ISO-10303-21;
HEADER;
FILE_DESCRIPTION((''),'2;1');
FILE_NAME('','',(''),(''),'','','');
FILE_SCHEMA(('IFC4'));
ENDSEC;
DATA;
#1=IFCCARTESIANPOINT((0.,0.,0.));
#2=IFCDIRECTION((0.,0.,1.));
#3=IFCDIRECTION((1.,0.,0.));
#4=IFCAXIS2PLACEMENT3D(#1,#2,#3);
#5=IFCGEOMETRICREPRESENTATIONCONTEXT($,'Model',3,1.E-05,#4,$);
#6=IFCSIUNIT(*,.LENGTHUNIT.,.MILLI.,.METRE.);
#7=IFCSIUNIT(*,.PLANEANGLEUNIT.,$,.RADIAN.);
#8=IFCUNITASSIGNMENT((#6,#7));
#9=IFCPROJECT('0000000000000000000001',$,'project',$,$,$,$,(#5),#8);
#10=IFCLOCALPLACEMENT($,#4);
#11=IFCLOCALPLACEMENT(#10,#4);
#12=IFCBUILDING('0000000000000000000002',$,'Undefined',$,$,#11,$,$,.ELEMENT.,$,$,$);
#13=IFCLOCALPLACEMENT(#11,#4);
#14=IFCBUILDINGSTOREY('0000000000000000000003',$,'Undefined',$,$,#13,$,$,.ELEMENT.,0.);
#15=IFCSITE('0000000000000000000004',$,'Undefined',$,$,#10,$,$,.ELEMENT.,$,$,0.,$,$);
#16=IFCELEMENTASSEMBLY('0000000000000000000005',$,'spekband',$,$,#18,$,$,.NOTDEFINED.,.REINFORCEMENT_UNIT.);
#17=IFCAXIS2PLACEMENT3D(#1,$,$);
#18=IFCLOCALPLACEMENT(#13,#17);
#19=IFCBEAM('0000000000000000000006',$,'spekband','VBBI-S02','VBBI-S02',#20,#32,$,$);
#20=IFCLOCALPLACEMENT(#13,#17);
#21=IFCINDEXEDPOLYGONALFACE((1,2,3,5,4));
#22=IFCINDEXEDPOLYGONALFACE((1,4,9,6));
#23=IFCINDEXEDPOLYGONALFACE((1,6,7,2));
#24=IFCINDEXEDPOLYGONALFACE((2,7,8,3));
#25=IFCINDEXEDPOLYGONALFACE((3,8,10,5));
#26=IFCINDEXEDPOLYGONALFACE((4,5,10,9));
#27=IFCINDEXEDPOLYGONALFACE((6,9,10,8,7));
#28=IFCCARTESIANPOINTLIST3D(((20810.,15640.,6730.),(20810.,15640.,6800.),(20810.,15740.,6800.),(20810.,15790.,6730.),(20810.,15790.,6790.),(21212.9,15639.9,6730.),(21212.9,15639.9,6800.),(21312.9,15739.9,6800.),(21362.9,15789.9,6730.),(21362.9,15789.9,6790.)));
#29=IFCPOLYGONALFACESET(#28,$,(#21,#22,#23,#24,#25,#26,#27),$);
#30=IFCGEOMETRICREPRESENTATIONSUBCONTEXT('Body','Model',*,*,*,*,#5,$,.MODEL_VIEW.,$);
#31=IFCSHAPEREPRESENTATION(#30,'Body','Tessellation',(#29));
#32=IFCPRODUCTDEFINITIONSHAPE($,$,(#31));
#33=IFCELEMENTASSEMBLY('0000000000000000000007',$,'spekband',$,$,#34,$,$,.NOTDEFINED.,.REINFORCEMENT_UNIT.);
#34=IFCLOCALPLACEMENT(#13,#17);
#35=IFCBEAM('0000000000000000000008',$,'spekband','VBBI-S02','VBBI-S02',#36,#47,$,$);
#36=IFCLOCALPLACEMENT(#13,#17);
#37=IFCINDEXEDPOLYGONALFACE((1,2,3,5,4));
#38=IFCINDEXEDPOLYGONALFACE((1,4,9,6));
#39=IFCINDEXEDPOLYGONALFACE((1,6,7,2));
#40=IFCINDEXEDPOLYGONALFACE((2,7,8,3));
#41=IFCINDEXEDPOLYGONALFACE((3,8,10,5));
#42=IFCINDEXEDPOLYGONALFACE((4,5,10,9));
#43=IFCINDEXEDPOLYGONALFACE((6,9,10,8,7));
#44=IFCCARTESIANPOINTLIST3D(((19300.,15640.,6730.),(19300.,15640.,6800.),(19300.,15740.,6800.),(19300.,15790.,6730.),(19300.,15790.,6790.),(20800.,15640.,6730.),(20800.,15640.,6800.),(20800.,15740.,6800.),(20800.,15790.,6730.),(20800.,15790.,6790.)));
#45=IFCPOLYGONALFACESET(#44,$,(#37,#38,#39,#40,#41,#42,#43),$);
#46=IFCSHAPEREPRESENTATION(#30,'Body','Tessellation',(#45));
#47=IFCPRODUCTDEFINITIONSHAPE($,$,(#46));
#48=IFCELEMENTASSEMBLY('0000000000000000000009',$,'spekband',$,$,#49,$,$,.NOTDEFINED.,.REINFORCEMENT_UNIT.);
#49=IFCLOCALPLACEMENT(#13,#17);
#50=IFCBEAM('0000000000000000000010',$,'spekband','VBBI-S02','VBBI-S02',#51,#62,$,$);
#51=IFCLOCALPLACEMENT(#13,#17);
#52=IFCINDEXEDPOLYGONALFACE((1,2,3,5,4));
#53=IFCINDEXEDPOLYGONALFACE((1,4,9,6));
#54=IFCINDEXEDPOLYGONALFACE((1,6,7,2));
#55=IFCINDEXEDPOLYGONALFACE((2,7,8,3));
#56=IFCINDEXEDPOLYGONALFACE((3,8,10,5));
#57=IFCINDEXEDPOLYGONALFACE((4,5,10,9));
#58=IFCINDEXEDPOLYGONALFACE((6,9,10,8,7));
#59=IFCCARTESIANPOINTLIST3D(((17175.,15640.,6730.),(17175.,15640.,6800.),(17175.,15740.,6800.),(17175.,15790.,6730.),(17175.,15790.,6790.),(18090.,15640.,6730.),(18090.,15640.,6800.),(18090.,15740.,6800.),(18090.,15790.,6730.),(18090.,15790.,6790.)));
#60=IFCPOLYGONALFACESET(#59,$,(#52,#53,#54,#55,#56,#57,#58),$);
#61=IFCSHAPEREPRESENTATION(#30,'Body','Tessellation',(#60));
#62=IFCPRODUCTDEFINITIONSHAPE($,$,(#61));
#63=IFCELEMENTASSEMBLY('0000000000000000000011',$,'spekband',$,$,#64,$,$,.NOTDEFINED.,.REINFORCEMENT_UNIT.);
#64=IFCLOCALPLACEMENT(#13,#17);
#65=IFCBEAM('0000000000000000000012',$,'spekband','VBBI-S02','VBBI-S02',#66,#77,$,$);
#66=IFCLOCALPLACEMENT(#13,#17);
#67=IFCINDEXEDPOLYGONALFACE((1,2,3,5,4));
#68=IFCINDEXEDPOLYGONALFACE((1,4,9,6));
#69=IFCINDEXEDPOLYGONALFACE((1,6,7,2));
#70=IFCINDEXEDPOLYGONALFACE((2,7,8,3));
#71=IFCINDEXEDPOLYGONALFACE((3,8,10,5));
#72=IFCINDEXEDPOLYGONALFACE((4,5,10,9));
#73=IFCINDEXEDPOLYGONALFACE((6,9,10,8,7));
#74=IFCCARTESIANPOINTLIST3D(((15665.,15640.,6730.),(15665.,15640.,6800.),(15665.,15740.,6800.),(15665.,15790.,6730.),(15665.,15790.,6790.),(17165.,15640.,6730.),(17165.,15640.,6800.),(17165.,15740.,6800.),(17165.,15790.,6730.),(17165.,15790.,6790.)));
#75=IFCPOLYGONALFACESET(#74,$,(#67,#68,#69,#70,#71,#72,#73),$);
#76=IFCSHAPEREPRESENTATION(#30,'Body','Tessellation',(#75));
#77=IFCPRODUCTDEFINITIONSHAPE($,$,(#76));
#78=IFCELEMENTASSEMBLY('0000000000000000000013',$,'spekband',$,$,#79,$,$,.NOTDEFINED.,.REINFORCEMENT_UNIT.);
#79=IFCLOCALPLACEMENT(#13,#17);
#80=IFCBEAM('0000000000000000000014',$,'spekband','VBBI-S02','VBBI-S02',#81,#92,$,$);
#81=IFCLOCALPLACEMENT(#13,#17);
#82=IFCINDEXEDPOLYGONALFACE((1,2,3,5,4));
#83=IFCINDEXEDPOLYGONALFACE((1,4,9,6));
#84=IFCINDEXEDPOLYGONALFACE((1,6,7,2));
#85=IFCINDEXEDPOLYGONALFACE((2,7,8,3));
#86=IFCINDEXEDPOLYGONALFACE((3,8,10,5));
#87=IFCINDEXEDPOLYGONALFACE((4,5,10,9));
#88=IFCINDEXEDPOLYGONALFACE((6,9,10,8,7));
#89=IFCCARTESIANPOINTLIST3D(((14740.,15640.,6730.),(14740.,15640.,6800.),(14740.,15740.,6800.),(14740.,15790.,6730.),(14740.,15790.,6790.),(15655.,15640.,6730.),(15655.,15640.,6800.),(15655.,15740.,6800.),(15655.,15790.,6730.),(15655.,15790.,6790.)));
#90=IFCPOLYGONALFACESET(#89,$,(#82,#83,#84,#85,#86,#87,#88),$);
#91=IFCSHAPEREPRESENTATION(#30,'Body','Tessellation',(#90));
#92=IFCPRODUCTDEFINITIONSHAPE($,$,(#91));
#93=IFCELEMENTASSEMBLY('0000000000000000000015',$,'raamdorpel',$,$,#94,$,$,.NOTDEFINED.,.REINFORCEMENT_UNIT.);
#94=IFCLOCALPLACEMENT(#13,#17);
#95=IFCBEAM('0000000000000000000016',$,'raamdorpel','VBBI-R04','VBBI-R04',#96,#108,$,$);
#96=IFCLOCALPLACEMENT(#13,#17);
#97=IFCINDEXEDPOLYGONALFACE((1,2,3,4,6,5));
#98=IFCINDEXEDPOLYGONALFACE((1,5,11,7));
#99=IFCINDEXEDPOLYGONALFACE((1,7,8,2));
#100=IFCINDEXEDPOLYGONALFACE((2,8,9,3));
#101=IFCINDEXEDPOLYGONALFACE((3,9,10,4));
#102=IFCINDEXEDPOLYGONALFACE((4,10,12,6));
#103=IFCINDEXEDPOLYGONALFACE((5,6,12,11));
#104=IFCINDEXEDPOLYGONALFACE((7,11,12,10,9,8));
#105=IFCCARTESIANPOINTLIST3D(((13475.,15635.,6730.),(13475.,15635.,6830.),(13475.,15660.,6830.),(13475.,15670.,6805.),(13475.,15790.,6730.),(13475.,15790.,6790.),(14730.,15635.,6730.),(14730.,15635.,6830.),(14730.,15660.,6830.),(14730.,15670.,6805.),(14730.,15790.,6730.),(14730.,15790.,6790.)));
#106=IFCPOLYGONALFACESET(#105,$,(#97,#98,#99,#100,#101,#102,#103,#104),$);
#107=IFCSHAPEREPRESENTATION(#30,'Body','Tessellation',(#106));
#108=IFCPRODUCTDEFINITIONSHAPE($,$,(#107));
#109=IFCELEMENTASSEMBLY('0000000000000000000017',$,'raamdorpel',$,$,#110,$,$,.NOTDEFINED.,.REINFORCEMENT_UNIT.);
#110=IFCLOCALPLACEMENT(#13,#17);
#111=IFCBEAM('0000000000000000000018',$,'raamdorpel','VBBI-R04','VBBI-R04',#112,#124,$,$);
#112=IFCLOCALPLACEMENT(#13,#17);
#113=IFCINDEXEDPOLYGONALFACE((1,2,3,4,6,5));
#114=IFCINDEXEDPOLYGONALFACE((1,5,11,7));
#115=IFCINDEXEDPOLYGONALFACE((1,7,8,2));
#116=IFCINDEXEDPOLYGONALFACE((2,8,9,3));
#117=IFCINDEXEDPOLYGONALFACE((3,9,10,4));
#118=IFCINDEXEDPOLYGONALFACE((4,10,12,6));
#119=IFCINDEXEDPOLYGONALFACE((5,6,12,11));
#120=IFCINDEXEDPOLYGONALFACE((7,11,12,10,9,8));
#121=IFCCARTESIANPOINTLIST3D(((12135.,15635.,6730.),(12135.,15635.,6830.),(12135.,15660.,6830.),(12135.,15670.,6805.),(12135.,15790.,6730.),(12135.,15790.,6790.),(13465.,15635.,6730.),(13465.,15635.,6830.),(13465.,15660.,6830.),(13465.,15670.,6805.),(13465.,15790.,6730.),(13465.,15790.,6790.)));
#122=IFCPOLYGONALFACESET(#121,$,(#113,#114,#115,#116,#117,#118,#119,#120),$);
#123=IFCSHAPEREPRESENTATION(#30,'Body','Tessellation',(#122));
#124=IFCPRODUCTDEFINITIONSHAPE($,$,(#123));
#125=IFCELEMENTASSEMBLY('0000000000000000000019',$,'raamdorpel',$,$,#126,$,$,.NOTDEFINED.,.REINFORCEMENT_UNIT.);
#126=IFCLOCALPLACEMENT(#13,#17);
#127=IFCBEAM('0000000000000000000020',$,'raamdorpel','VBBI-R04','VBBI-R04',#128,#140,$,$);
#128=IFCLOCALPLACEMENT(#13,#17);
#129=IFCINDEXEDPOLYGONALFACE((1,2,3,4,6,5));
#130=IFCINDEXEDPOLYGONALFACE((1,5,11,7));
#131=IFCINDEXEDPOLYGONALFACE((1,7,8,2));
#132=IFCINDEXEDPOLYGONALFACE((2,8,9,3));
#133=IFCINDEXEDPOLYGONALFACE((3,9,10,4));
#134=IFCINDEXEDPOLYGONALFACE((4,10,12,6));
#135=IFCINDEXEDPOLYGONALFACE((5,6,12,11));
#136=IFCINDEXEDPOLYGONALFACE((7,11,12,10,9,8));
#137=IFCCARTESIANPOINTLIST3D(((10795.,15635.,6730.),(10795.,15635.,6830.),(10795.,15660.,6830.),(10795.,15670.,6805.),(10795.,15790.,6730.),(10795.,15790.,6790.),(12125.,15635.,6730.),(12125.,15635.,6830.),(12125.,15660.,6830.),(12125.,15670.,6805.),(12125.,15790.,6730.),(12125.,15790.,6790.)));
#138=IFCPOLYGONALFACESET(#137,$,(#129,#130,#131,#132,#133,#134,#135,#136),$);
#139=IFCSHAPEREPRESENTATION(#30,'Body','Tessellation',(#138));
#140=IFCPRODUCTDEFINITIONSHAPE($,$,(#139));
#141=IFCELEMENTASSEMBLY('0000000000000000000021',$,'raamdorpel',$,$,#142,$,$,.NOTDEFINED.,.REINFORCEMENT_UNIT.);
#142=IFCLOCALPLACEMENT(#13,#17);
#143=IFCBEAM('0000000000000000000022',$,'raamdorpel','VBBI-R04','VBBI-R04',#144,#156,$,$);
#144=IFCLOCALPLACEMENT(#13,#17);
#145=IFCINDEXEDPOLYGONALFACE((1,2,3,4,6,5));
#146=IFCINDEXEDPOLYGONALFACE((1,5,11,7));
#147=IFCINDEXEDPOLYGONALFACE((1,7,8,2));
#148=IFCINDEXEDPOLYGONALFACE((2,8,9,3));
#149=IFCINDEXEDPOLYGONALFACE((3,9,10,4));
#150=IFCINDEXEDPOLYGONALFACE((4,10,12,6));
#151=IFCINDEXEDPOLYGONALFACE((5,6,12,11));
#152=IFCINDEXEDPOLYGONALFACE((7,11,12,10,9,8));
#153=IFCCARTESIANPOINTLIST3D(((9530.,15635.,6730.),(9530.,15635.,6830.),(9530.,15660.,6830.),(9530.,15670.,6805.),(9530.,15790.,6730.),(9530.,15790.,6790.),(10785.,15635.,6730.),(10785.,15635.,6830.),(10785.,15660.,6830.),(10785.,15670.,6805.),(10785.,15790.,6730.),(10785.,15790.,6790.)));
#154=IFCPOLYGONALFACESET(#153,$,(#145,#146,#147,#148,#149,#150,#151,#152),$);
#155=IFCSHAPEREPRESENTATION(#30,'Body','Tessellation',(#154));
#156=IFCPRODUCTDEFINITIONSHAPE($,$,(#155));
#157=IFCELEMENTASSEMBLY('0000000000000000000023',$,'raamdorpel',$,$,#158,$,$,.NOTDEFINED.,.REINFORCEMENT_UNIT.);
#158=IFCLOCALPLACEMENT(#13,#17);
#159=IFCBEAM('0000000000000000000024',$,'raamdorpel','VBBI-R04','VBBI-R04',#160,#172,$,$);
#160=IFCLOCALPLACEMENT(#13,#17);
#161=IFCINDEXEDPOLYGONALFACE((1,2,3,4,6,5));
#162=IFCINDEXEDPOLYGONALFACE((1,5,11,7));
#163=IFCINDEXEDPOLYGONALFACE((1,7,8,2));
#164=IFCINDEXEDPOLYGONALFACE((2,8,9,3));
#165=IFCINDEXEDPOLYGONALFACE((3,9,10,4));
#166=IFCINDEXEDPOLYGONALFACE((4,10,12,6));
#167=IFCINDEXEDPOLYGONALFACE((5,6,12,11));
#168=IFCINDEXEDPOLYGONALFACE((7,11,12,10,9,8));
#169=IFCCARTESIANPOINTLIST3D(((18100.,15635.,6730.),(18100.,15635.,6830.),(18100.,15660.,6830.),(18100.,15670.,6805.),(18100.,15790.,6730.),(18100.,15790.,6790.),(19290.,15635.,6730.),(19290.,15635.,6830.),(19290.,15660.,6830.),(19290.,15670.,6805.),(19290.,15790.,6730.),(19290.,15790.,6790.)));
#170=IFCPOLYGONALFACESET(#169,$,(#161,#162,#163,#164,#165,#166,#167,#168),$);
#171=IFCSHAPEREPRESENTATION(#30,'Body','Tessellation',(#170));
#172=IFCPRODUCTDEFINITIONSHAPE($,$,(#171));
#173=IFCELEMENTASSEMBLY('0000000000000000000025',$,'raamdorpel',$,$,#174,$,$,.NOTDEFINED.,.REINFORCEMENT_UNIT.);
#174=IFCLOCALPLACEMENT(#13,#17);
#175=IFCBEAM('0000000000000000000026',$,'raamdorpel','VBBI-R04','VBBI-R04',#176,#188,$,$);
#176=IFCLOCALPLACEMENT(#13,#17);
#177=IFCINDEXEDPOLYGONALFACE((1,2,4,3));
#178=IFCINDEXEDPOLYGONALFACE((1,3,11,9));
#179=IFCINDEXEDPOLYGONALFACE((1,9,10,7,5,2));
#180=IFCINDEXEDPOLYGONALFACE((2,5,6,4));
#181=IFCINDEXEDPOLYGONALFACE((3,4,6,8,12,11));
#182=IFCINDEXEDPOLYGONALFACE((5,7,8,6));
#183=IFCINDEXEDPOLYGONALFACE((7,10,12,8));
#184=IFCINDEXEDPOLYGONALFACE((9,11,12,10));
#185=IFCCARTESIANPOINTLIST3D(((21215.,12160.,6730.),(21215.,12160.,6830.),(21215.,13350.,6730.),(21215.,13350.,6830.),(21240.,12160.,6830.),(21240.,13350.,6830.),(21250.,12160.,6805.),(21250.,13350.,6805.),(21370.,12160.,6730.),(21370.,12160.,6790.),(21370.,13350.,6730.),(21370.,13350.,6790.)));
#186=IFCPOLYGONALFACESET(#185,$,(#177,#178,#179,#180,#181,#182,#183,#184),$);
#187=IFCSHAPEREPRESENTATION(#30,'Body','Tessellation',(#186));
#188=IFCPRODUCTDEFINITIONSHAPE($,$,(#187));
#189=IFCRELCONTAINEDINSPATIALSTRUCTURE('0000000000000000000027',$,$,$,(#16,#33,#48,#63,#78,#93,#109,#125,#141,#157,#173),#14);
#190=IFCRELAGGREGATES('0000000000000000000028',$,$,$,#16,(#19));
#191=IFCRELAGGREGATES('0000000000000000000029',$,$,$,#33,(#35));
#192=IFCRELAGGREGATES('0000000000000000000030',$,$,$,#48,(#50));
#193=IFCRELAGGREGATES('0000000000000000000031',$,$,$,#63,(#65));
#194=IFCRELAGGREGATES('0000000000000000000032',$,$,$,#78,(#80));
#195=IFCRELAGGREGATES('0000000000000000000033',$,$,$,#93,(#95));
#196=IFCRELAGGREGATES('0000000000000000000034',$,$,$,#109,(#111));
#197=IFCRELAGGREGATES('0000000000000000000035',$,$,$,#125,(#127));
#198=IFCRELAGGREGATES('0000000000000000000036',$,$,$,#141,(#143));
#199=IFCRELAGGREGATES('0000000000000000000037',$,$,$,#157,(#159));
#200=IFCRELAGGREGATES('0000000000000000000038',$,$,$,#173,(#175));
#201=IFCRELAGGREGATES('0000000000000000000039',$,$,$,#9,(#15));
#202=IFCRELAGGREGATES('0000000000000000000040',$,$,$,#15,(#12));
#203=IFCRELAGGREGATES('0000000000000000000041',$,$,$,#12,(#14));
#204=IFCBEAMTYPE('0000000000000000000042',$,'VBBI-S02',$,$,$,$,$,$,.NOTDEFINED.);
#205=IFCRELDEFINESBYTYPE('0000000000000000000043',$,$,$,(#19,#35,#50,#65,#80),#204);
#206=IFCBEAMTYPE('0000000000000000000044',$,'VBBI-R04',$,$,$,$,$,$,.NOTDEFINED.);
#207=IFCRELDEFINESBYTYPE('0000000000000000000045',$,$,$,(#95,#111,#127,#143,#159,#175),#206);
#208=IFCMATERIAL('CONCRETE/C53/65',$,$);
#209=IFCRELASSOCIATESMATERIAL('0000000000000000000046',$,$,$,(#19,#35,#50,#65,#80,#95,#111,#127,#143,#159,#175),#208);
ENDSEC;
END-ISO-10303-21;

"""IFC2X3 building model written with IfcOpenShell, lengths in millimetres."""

from ifc_helpers import new_model, si_unit, frame, origin_with_axes, place, context, subcontext, project, spatial, polyline, outline, extrude, clip, halfspace, material, type_object, element, aggregate, save


model = new_model("IFC2X3")

# Units and contexts
model_context = context("Model", 3, precision=1e-05, world=origin_with_axes())
body_context = subcontext(model_context, "Body", "Model", "MODEL_VIEW")
ifc_project = project(units=[si_unit("LENGTHUNIT", "METRE", prefix="MILLI"), si_unit("PLANEANGLEUNIT", "RADIAN")], contexts=[model_context])

# Site, building, storey
site_placement = place(None, origin_with_axes())
site = spatial("IfcSite", under=ifc_project, at=site_placement, Name="Undefined", CompositionType="ELEMENT", RefElevation=0.0)
building_placement = place(site_placement, origin_with_axes())
building = spatial("IfcBuilding", under=site, at=building_placement, Name="Undefined", CompositionType="ELEMENT")
storey_placement = place(building_placement, origin_with_axes())
storey = spatial("IfcBuildingStorey", under=building, at=storey_placement, Name="Undefined", CompositionType="ELEMENT", Elevation=0.0)

# Element assemblies, beams
ifc_material = material(Name="CONCRETE/C53/65")
beam_type_1 = type_object("IfcBeamType", Name="VBBI-S02", PredefinedType="NOTDEFINED")
assembly_1_placement = place(storey_placement, origin_with_axes())
assembly_1 = element("IfcElementAssembly", 1, at=assembly_1_placement, inside=storey, Name="spekband", AssemblyPlace="NOTDEFINED", PredefinedType="REINFORCEMENT_UNIT")
beam_1_placement = place(assembly_1_placement, frame((21370.0, 15714.9, 6765.0), z_axis=(0.000138, 1.0, 0.0), x_axis=(-1.0, 0.000138, 0.0)))
beam_1 = element("IfcBeam", 2, at=beam_1_placement, type_object=beam_type_1, material=ifc_material, Name="spekband", Description="VBBI-S02", ObjectType="VBBI-S02", context=body_context, shape_type="Clipping", body=[
    clip(extrude(outline(polyline([(35.0, -75.0), (-35.0, -75.0), (-35.0, 25.0), (-25.0, 75.0), (35.0, 75.0), (35.0, -75.0)])), frame((560.0, 0.0, 0.0), z_axis=(-1.0, 0.0, 0.0), x_axis=(0.0, -1.0, 0.0)), (0.0, 0.0, 1.0), 553.7), halfspace(frame((3.5, 0.0, 78.5), z_axis=(0.707156, 0.0, 0.707057), x_axis=(0.0, 1.0, 0.0)), True)),
])
aggregate(assembly_1, [beam_1])
assembly_2_placement = place(storey_placement, origin_with_axes())
assembly_2 = element("IfcElementAssembly", 3, at=assembly_2_placement, inside=storey, Name="spekband", AssemblyPlace="NOTDEFINED", PredefinedType="REINFORCEMENT_UNIT")
beam_2_placement = place(assembly_2_placement, frame((20800.0, 15715.0, 6765.0), z_axis=(0.0, 1.0, 0.0), x_axis=(-1.0, 0.0, 0.0)))
beam_2 = element("IfcBeam", 4, at=beam_2_placement, type_object=beam_type_1, material=ifc_material, Name="spekband", Description="VBBI-S02", ObjectType="VBBI-S02", context=body_context, shape_type="SweptSolid", body=[
    extrude(outline(polyline([(35.0, -75.0), (-35.0, -75.0), (-35.0, 25.0), (-25.0, 75.0), (35.0, 75.0), (35.0, -75.0)])), frame((1500.0, 0.0, 0.0), z_axis=(-1.0, 0.0, 0.0), x_axis=(0.0, -1.0, 0.0)), (0.0, 0.0, 1.0), 1500.0),
])
aggregate(assembly_2, [beam_2])
assembly_3_placement = place(storey_placement, origin_with_axes())
assembly_3 = element("IfcElementAssembly", 5, at=assembly_3_placement, inside=storey, Name="spekband", AssemblyPlace="NOTDEFINED", PredefinedType="REINFORCEMENT_UNIT")
beam_3_placement = place(assembly_3_placement, frame((18090.0, 15715.0, 6765.0), z_axis=(0.0, 1.0, 0.0), x_axis=(-1.0, 0.0, 0.0)))
beam_3 = element("IfcBeam", 6, at=beam_3_placement, type_object=beam_type_1, material=ifc_material, Name="spekband", Description="VBBI-S02", ObjectType="VBBI-S02", context=body_context, shape_type="SweptSolid", body=[
    extrude(outline(polyline([(35.0, -75.0), (-35.0, -75.0), (-35.0, 25.0), (-25.0, 75.0), (35.0, 75.0), (35.0, -75.0)])), frame((915.0, 0.0, 0.0), z_axis=(-1.0, 0.0, 0.0), x_axis=(0.0, -1.0, 0.0)), (0.0, 0.0, 1.0), 915.0),
])
aggregate(assembly_3, [beam_3])
assembly_4_placement = place(storey_placement, origin_with_axes())
assembly_4 = element("IfcElementAssembly", 7, at=assembly_4_placement, inside=storey, Name="spekband", AssemblyPlace="NOTDEFINED", PredefinedType="REINFORCEMENT_UNIT")
beam_4_placement = place(assembly_4_placement, frame((17165.0, 15715.0, 6765.0), z_axis=(0.0, 1.0, 0.0), x_axis=(-1.0, 0.0, 0.0)))
beam_4 = element("IfcBeam", 8, at=beam_4_placement, type_object=beam_type_1, material=ifc_material, Name="spekband", Description="VBBI-S02", ObjectType="VBBI-S02", context=body_context, shape_type="SweptSolid", body=[
    extrude(outline(polyline([(35.0, -75.0), (-35.0, -75.0), (-35.0, 25.0), (-25.0, 75.0), (35.0, 75.0), (35.0, -75.0)])), frame((1500.0, 0.0, 0.0), z_axis=(-1.0, 0.0, 0.0), x_axis=(0.0, -1.0, 0.0)), (0.0, 0.0, 1.0), 1500.0),
])
aggregate(assembly_4, [beam_4])
assembly_5_placement = place(storey_placement, origin_with_axes())
assembly_5 = element("IfcElementAssembly", 9, at=assembly_5_placement, inside=storey, Name="spekband", AssemblyPlace="NOTDEFINED", PredefinedType="REINFORCEMENT_UNIT")
beam_5_placement = place(assembly_5_placement, frame((15655.0, 15715.0, 6765.0), z_axis=(0.0, 1.0, 0.0), x_axis=(-1.0, 0.0, 0.0)))
beam_5 = element("IfcBeam", 10, at=beam_5_placement, type_object=beam_type_1, material=ifc_material, Name="spekband", Description="VBBI-S02", ObjectType="VBBI-S02", context=body_context, shape_type="SweptSolid", body=[
    extrude(outline(polyline([(35.0, -75.0), (-35.0, -75.0), (-35.0, 25.0), (-25.0, 75.0), (35.0, 75.0), (35.0, -75.0)])), frame((915.0, 0.0, 0.0), z_axis=(-1.0, 0.0, 0.0), x_axis=(0.0, -1.0, 0.0)), (0.0, 0.0, 1.0), 915.0),
])
aggregate(assembly_5, [beam_5])
assembly_6_placement = place(storey_placement, origin_with_axes())
assembly_6 = element("IfcElementAssembly", 11, at=assembly_6_placement, inside=storey, Name="raamdorpel", AssemblyPlace="NOTDEFINED", PredefinedType="REINFORCEMENT_UNIT")
beam_type_2 = type_object("IfcBeamType", Name="VBBI-R04", PredefinedType="NOTDEFINED")
beam_6_placement = place(assembly_6_placement, frame((14730.0, 15712.5, 6780.0), z_axis=(0.0, 1.0, 0.0), x_axis=(-1.0, 0.0, 0.0)))
beam_6 = element("IfcBeam", 12, at=beam_6_placement, type_object=beam_type_2, material=ifc_material, Name="raamdorpel", Description="VBBI-R04", ObjectType="VBBI-R04", context=body_context, shape_type="SweptSolid", body=[
    extrude(outline(polyline([(50.0, -77.5), (-50.0, -77.5), (-50.0, -52.5), (-25.0, -42.5), (-10.0, 77.5), (50.0, 77.5), (50.0, -77.5)])), frame((1255.0, 0.0, 0.0), z_axis=(-1.0, 0.0, 0.0), x_axis=(0.0, -1.0, 0.0)), (0.0, 0.0, 1.0), 1255.0),
])
aggregate(assembly_6, [beam_6])
assembly_7_placement = place(storey_placement, origin_with_axes())
assembly_7 = element("IfcElementAssembly", 13, at=assembly_7_placement, inside=storey, Name="raamdorpel", AssemblyPlace="NOTDEFINED", PredefinedType="REINFORCEMENT_UNIT")
beam_7_placement = place(assembly_7_placement, frame((13465.0, 15712.5, 6780.0), z_axis=(0.0, 1.0, 0.0), x_axis=(-1.0, 0.0, 0.0)))
beam_7 = element("IfcBeam", 14, at=beam_7_placement, type_object=beam_type_2, material=ifc_material, Name="raamdorpel", Description="VBBI-R04", ObjectType="VBBI-R04", context=body_context, shape_type="SweptSolid", body=[
    extrude(outline(polyline([(50.0, -77.5), (-50.0, -77.5), (-50.0, -52.5), (-25.0, -42.5), (-10.0, 77.5), (50.0, 77.5), (50.0, -77.5)])), frame((1330.0, 0.0, 0.0), z_axis=(-1.0, 0.0, 0.0), x_axis=(0.0, -1.0, 0.0)), (0.0, 0.0, 1.0), 1330.0),
])
aggregate(assembly_7, [beam_7])
assembly_8_placement = place(storey_placement, origin_with_axes())
assembly_8 = element("IfcElementAssembly", 15, at=assembly_8_placement, inside=storey, Name="raamdorpel", AssemblyPlace="NOTDEFINED", PredefinedType="REINFORCEMENT_UNIT")
beam_8_placement = place(assembly_8_placement, frame((12125.0, 15712.5, 6780.0), z_axis=(0.0, 1.0, 0.0), x_axis=(-1.0, 0.0, 0.0)))
beam_8 = element("IfcBeam", 16, at=beam_8_placement, type_object=beam_type_2, material=ifc_material, Name="raamdorpel", Description="VBBI-R04", ObjectType="VBBI-R04", context=body_context, shape_type="SweptSolid", body=[
    extrude(outline(polyline([(50.0, -77.5), (-50.0, -77.5), (-50.0, -52.5), (-25.0, -42.5), (-10.0, 77.5), (50.0, 77.5), (50.0, -77.5)])), frame((1330.0, 0.0, 0.0), z_axis=(-1.0, 0.0, 0.0), x_axis=(0.0, -1.0, 0.0)), (0.0, 0.0, 1.0), 1330.0),
])
aggregate(assembly_8, [beam_8])
assembly_9_placement = place(storey_placement, origin_with_axes())
assembly_9 = element("IfcElementAssembly", 17, at=assembly_9_placement, inside=storey, Name="raamdorpel", AssemblyPlace="NOTDEFINED", PredefinedType="REINFORCEMENT_UNIT")
beam_9_placement = place(assembly_9_placement, frame((10785.0, 15712.5, 6780.0), z_axis=(0.0, 1.0, 0.0), x_axis=(-1.0, 0.0, 0.0)))
beam_9 = element("IfcBeam", 18, at=beam_9_placement, type_object=beam_type_2, material=ifc_material, Name="raamdorpel", Description="VBBI-R04", ObjectType="VBBI-R04", context=body_context, shape_type="SweptSolid", body=[
    extrude(outline(polyline([(50.0, -77.5), (-50.0, -77.5), (-50.0, -52.5), (-25.0, -42.5), (-10.0, 77.5), (50.0, 77.5), (50.0, -77.5)])), frame((1255.0, 0.0, 0.0), z_axis=(-1.0, 0.0, 0.0), x_axis=(0.0, -1.0, 0.0)), (0.0, 0.0, 1.0), 1255.0),
])
aggregate(assembly_9, [beam_9])
assembly_10_placement = place(storey_placement, origin_with_axes())
assembly_10 = element("IfcElementAssembly", 19, at=assembly_10_placement, inside=storey, Name="raamdorpel", AssemblyPlace="NOTDEFINED", PredefinedType="REINFORCEMENT_UNIT")
beam_10_placement = place(assembly_10_placement, frame((19290.0, 15712.5, 6780.0), z_axis=(0.0, 1.0, 0.0), x_axis=(-1.0, 0.0, 0.0)))
beam_10 = element("IfcBeam", 20, at=beam_10_placement, type_object=beam_type_2, material=ifc_material, Name="raamdorpel", Description="VBBI-R04", ObjectType="VBBI-R04", context=body_context, shape_type="SweptSolid", body=[
    extrude(outline(polyline([(50.0, -77.5), (-50.0, -77.5), (-50.0, -52.5), (-25.0, -42.5), (-10.0, 77.5), (50.0, 77.5), (50.0, -77.5)])), frame((1190.0, 0.0, 0.0), z_axis=(-1.0, 0.0, 0.0), x_axis=(0.0, -1.0, 0.0)), (0.0, 0.0, 1.0), 1190.0),
])
aggregate(assembly_10, [beam_10])
assembly_11_placement = place(storey_placement, origin_with_axes())
assembly_11 = element("IfcElementAssembly", 21, at=assembly_11_placement, inside=storey, Name="raamdorpel", AssemblyPlace="NOTDEFINED", PredefinedType="REINFORCEMENT_UNIT")
beam_11_placement = place(assembly_11_placement, frame((21292.5, 12160.0, 6780.0), z_axis=(1.0, 0.0, 0.0), x_axis=(0.0, 1.0, 0.0)))
beam_11 = element("IfcBeam", 22, at=beam_11_placement, type_object=beam_type_2, material=ifc_material, Name="raamdorpel", Description="VBBI-R04", ObjectType="VBBI-R04", context=body_context, shape_type="SweptSolid", body=[
    extrude(outline(polyline([(50.0, -77.5), (-50.0, -77.5), (-50.0, -52.5), (-25.0, -42.5), (-10.0, 77.5), (50.0, 77.5), (50.0, -77.5)])), frame((1190.0, 0.0, 0.0), z_axis=(-1.0, 0.0, 0.0), x_axis=(0.0, -1.0, 0.0)), (0.0, 0.0, 1.0), 1190.0),
])
aggregate(assembly_11, [beam_11])

save(model, "model.ifc")
